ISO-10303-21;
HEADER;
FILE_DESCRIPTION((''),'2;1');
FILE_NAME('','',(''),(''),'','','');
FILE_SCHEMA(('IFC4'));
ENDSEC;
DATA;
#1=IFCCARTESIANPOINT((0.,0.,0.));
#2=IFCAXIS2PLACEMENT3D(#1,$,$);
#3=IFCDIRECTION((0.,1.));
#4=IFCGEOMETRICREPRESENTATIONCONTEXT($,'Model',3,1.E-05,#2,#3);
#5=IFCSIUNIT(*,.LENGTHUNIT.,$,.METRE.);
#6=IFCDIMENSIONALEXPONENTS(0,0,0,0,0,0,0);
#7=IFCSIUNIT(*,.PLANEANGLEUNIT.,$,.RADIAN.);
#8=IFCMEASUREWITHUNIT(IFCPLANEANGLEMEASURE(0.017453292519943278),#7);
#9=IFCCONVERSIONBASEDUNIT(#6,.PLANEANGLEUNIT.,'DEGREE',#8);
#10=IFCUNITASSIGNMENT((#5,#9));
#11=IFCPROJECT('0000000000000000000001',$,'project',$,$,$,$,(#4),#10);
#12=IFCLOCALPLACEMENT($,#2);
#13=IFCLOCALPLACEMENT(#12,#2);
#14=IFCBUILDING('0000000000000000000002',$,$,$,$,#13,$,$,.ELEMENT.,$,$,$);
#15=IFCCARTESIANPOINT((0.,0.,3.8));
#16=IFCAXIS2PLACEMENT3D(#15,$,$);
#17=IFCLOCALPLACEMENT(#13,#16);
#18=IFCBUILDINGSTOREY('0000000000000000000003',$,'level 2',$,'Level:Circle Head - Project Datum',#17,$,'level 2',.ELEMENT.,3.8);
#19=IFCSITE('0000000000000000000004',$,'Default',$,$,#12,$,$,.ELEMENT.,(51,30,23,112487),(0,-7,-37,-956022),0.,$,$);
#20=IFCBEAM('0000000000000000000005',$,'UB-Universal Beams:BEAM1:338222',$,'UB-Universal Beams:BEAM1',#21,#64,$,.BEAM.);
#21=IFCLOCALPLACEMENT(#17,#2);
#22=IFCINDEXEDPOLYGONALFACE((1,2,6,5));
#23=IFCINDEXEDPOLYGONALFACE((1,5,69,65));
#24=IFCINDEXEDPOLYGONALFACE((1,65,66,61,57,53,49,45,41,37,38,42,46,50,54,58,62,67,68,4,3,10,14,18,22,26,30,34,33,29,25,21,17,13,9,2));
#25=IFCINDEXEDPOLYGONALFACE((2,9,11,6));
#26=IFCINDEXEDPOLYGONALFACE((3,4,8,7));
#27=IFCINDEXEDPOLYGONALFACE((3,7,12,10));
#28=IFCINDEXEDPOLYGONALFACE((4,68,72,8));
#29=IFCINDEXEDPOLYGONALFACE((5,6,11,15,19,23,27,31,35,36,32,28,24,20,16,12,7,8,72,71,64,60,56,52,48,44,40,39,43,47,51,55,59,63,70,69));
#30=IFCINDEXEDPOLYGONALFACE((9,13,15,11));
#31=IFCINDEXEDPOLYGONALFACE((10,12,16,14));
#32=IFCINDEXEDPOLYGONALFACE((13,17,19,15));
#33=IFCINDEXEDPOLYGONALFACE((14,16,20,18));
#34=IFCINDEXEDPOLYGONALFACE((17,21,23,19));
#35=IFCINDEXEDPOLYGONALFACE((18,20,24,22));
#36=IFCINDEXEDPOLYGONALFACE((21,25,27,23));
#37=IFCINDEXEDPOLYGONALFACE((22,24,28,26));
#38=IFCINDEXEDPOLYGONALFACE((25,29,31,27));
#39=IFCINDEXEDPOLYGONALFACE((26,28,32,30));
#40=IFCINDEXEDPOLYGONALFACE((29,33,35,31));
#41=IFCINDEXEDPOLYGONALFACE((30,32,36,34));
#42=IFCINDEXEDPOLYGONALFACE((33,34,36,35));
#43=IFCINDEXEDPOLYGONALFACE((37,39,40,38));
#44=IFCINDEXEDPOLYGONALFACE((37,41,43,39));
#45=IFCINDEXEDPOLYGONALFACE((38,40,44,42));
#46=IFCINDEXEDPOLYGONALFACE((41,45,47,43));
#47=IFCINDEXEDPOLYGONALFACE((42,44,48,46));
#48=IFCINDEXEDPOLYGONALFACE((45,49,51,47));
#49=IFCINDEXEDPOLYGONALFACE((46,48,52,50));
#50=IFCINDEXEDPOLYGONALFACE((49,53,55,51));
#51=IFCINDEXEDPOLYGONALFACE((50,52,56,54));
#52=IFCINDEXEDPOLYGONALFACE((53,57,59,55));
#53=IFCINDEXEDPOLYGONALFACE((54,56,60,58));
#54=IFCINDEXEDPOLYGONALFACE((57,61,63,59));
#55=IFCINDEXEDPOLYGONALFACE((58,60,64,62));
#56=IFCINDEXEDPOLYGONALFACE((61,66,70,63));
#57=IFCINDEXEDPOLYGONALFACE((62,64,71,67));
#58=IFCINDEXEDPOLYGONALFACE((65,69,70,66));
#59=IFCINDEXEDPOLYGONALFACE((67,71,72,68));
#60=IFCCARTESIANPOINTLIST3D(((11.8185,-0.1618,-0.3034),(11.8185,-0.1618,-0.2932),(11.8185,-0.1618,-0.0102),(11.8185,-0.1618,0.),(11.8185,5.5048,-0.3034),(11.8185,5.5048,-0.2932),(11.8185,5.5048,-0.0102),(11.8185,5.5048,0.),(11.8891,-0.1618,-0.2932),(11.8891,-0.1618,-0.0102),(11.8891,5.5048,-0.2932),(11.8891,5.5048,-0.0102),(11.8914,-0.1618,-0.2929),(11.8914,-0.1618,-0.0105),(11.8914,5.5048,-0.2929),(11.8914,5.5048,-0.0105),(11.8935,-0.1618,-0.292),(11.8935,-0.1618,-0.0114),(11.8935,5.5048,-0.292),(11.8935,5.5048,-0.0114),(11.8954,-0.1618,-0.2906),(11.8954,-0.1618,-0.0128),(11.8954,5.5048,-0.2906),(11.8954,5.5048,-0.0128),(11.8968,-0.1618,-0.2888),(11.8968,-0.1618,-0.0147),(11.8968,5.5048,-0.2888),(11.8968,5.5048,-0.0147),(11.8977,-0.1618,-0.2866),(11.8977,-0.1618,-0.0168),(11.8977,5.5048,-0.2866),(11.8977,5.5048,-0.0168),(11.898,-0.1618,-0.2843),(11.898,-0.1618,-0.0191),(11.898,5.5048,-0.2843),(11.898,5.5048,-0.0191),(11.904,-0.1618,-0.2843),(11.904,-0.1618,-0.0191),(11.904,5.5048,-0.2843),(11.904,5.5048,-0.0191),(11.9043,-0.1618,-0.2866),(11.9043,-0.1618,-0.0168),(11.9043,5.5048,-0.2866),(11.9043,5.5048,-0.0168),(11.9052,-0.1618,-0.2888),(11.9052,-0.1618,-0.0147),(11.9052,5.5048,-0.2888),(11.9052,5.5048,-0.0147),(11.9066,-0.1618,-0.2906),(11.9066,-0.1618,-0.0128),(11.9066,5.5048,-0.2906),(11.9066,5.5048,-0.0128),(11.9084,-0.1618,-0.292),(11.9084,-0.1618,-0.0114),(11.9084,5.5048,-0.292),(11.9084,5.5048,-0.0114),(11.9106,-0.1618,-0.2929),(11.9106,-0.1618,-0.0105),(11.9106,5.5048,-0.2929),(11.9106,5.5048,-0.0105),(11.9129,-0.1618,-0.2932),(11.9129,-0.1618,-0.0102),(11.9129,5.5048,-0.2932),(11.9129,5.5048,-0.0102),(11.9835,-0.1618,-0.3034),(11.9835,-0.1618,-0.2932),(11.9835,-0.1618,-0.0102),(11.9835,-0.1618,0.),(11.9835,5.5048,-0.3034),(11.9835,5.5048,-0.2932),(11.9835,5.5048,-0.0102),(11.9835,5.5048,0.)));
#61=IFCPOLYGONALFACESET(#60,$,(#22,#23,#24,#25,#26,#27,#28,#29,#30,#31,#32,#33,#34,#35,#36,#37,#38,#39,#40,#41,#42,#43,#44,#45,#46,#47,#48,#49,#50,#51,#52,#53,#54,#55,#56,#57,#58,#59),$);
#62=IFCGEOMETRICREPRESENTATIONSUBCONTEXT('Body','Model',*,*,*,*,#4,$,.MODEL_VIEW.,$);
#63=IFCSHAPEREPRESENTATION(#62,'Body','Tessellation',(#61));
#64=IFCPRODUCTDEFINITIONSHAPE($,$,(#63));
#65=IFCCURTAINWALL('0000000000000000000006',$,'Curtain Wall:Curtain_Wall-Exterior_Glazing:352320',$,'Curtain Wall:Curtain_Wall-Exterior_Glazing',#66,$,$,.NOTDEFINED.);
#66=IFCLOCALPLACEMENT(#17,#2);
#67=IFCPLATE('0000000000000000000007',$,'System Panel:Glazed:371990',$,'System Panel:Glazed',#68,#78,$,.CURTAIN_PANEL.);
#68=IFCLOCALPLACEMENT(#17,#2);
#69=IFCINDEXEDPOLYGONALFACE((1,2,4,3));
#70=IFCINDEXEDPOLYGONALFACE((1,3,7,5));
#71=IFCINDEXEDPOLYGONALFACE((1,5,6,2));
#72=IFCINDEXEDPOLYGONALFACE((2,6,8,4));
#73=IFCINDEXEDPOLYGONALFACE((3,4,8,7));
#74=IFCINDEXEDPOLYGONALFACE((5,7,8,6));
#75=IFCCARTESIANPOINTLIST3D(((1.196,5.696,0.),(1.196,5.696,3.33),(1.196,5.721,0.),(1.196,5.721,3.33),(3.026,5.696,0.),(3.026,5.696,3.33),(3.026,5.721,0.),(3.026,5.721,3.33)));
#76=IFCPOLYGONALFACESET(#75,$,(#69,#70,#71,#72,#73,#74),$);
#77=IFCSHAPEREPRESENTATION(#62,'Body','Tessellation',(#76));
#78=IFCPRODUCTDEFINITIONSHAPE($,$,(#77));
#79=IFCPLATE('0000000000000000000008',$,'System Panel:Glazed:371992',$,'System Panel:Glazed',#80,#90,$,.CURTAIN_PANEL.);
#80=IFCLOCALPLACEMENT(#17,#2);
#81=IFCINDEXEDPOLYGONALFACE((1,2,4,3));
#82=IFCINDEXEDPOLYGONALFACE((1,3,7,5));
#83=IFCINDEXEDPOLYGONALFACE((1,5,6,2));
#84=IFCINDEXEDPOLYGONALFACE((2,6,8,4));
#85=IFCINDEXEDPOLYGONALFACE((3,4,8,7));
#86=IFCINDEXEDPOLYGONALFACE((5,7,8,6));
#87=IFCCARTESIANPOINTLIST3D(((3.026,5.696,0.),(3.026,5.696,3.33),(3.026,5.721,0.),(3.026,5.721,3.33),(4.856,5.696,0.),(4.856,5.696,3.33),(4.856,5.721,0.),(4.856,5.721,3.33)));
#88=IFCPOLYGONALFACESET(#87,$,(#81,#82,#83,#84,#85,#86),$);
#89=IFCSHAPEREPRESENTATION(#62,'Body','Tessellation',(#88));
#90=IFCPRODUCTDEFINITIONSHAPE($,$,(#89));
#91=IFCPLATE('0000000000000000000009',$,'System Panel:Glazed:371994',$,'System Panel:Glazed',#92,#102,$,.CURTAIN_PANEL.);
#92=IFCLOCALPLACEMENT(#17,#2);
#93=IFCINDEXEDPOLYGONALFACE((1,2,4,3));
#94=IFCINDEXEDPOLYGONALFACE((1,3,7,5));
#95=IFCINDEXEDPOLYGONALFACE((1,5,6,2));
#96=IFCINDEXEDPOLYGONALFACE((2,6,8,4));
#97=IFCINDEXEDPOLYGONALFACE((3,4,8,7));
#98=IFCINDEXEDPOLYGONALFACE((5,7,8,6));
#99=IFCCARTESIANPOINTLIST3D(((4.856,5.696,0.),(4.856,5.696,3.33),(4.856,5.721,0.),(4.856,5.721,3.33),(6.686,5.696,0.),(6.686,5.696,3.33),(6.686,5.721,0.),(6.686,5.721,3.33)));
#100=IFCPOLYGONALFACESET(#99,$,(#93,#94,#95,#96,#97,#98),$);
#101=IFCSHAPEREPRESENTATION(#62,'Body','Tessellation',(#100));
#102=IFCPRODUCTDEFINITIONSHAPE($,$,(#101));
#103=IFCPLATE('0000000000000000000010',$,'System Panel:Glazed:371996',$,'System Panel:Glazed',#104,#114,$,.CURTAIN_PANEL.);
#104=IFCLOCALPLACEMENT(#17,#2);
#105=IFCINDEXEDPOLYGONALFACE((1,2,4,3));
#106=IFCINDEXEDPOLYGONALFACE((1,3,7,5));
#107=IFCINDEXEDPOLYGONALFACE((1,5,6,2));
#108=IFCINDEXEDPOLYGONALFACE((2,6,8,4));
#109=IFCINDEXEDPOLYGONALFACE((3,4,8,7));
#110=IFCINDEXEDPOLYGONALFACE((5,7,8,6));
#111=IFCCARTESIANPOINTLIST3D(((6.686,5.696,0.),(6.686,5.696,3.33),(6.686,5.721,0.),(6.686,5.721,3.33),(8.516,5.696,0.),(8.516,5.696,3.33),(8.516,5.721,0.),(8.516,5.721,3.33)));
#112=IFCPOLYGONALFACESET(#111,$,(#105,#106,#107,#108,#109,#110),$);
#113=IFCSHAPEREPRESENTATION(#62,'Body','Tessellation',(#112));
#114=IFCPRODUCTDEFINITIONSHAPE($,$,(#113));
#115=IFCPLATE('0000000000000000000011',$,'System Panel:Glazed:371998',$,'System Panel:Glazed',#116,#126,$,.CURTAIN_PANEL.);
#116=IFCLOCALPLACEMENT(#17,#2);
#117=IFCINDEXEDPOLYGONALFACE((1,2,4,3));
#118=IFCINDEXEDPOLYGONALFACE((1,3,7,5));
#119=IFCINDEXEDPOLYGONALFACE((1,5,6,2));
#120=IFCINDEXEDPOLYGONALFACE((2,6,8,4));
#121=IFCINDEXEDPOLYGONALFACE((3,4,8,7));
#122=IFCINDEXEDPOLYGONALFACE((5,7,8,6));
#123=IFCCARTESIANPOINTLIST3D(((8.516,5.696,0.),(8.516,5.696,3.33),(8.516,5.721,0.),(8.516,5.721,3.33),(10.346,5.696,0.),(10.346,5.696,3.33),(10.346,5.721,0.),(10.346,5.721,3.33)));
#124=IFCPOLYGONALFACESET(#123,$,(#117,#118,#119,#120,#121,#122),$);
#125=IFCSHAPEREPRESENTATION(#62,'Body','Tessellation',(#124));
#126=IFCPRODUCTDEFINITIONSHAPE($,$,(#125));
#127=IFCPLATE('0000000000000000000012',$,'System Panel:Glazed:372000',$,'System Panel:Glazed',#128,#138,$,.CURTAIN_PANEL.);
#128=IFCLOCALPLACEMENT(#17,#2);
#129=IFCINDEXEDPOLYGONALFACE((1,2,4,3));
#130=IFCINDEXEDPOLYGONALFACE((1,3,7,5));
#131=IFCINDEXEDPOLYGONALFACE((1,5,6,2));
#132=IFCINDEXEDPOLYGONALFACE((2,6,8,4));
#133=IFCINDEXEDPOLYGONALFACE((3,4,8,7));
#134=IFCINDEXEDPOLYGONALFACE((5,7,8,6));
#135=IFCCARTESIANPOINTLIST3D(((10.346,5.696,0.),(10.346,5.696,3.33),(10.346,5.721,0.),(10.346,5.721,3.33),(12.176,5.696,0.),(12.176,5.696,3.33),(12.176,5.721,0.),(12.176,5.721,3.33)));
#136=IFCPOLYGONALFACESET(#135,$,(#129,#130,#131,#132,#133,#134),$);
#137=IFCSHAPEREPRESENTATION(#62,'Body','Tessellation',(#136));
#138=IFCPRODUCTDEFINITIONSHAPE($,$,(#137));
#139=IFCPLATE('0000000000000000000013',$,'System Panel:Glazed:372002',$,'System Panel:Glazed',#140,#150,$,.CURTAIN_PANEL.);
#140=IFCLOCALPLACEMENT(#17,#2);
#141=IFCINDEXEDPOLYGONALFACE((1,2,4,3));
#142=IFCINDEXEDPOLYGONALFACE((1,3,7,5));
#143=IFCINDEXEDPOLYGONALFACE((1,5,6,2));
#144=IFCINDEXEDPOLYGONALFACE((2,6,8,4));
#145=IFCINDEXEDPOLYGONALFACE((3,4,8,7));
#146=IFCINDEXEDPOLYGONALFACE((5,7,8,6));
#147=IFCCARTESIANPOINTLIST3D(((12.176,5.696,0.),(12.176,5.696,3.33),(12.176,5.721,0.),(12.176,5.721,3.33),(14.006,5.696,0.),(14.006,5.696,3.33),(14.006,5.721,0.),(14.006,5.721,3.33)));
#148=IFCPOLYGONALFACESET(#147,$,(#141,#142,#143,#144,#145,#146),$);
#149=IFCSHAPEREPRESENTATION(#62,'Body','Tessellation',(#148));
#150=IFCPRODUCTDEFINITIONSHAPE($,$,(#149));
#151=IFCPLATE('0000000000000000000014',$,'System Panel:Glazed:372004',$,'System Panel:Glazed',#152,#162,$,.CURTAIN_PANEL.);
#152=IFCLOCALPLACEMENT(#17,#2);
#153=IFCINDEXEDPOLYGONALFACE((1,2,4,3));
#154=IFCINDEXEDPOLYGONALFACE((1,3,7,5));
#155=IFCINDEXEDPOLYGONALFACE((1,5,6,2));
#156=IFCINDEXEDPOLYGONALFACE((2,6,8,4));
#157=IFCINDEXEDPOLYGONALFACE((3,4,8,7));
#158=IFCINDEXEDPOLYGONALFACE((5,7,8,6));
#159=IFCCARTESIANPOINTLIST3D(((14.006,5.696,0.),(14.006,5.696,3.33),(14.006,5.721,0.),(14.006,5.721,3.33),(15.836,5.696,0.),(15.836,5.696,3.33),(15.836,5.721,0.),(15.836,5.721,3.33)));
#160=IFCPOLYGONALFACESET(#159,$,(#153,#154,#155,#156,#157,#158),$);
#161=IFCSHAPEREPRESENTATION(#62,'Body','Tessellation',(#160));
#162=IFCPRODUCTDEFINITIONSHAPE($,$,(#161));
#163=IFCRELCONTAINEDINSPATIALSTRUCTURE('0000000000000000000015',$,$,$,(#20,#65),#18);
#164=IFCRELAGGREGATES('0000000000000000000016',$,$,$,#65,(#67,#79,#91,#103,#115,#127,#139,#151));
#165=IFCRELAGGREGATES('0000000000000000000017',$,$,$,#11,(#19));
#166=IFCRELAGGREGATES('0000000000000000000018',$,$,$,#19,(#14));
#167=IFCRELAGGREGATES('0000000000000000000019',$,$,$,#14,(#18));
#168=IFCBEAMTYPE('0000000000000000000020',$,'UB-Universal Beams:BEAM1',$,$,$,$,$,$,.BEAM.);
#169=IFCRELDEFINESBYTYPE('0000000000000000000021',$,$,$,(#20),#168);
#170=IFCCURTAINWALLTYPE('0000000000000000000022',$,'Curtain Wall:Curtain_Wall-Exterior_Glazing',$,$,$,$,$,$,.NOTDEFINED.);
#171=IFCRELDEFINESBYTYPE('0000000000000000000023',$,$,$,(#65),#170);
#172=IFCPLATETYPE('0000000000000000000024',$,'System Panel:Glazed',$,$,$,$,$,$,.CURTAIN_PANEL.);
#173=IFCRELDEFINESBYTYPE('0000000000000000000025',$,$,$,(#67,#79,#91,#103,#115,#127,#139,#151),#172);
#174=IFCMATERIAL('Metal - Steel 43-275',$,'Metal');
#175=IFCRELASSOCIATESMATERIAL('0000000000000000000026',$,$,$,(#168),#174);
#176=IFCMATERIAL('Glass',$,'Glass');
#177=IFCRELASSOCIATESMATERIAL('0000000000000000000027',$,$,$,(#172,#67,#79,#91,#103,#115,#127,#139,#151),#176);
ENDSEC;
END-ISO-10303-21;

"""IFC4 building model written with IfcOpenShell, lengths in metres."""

from ifc_helpers import new_model, entity, si_unit, converted_unit, direction, frame, frame_2d, origin, origin_2d_with_axis, place, context, subcontext, project, spatial, polyline, circle_curve, parameter, trimmed, segment, composite_curve, rectangle, outline, extrude, source, transform, mapped, material, material_profile, profile_set, type_object, type_shapes, element, aggregate, save


model = new_model("IFC4")

# Units and contexts
model_context = context("Model", 3, precision=1e-05, world=origin(), true_north=direction((0.0, 1.0)))
body_context = subcontext(model_context, "Body", "Model", "MODEL_VIEW")
ifc_project = project(units=[si_unit("LENGTHUNIT", "METRE"), converted_unit("PLANEANGLEUNIT", "DEGREE", entity("IfcPlaneAngleMeasure", 0.017453292519943278), si_unit("PLANEANGLEUNIT", "RADIAN"), dimensions=[0, 0, 0, 0, 0, 0, 0])], contexts=[model_context])

# Site, building, storey
site_placement = place(None, origin())
site = spatial("IfcSite", under=ifc_project, at=site_placement, Name="Default", CompositionType="ELEMENT", RefLatitude=(51, 30, 23, 112487), RefLongitude=(0, -7, -37, -956022), RefElevation=0.0)
building_placement = place(site_placement, origin())
building = spatial("IfcBuilding", under=site, at=building_placement, CompositionType="ELEMENT")
storey_placement = place(building_placement, frame((0.0, 0.0, 3.8)))
storey = spatial("IfcBuildingStorey", under=building, at=storey_placement, Name="level 2", ObjectType="Level:Circle Head - Project Datum", LongName="level 2", CompositionType="ELEMENT", Elevation=3.8)

# Shared definitions
ifc_material_1 = material(Name="Metal - Steel 43-275", Category="Metal")

# Beam
ifc_material_profile_1 = material_profile(ifc_material_1, outline(composite_curve([segment(polyline([(-0.0825, -0.1415), (-0.0825, -0.1517)]), True, "CONTINUOUS"), segment(polyline([(-0.0825, -0.1517), (0.0825, -0.1517)]), True, "CONTINUOUS"), segment(polyline([(0.0825, -0.1517), (0.0825, -0.1415)]), True, "CONTINUOUS"), segment(polyline([(0.0825, -0.1415), (0.0119, -0.1415)]), True, "CONTINUOUS"), segment(trimmed(circle_curve(frame_2d((0.0119, -0.1326), x_axis=(1.0, 0.0)), 0.0089), [parameter(180.0)], [parameter(270.0)], True, "PARAMETER"), False, "CONTINUOUS"), segment(polyline([(0.003, -0.1326), (0.003, 0.1326)]), True, "CONTINUOUS"), segment(trimmed(circle_curve(frame_2d((0.0119, 0.1326), x_axis=(1.0, 0.0)), 0.0089), [parameter(90.0)], [parameter(180.0)], True, "PARAMETER"), False, "CONTINUOUS"), segment(polyline([(0.0119, 0.1415), (0.0825, 0.1415)]), True, "CONTINUOUS"), segment(polyline([(0.0825, 0.1415), (0.0825, 0.1517)]), True, "CONTINUOUS"), segment(polyline([(0.0825, 0.1517), (-0.0825, 0.1517)]), True, "CONTINUOUS"), segment(polyline([(-0.0825, 0.1517), (-0.0825, 0.1415)]), True, "CONTINUOUS"), segment(polyline([(-0.0825, 0.1415), (-0.0119, 0.1415)]), True, "CONTINUOUS"), segment(trimmed(circle_curve(frame_2d((-0.0119, 0.1326), x_axis=(1.0, 0.0)), 0.0089), [parameter(360.0)], [parameter(90.0)], True, "PARAMETER"), False, "CONTINUOUS"), segment(polyline([(-0.003, 0.1326), (-0.003, -0.1326)]), True, "CONTINUOUS"), segment(trimmed(circle_curve(frame_2d((-0.0119, -0.1326), x_axis=(1.0, 0.0)), 0.0089), [parameter(270.0)], [parameter(360.0)], True, "PARAMETER"), False, "CONTINUOUS"), segment(polyline([(-0.0119, -0.1415), (-0.0825, -0.1415)]), True, "CONTINUOUS")], self_intersect=False)), Name="BEAM1")
ifc_profile_set_1 = profile_set([ifc_material_profile_1], Name="BEAM1")
beam_type_1 = type_object("IfcBeamType", Name="UB-Universal Beams:BEAM1", PredefinedType="BEAM", material=ifc_profile_set_1)
shared_shape_1 = source(origin(), body_context, "Body", "SweptSolid", [
    extrude(outline(composite_curve([segment(polyline([(-0.0825, -0.1415), (-0.0825, -0.1517)]), True, "CONTINUOUS"), segment(polyline([(-0.0825, -0.1517), (0.0825, -0.1517)]), True, "CONTINUOUS"), segment(polyline([(0.0825, -0.1517), (0.0825, -0.1415)]), True, "CONTINUOUS"), segment(polyline([(0.0825, -0.1415), (0.0119, -0.1415)]), True, "CONTINUOUS"), segment(trimmed(circle_curve(frame_2d((0.0119, -0.1326), x_axis=(1.0, 0.0)), 0.0089), [parameter(180.0)], [parameter(270.0)], True, "PARAMETER"), False, "CONTINUOUS"), segment(polyline([(0.003, -0.1326), (0.003, 0.1326)]), True, "CONTINUOUS"), segment(trimmed(circle_curve(frame_2d((0.0119, 0.1326), x_axis=(1.0, 0.0)), 0.0089), [parameter(90.0)], [parameter(180.0)], True, "PARAMETER"), False, "CONTINUOUS"), segment(polyline([(0.0119, 0.1415), (0.0825, 0.1415)]), True, "CONTINUOUS"), segment(polyline([(0.0825, 0.1415), (0.0825, 0.1517)]), True, "CONTINUOUS"), segment(polyline([(0.0825, 0.1517), (-0.0825, 0.1517)]), True, "CONTINUOUS"), segment(polyline([(-0.0825, 0.1517), (-0.0825, 0.1415)]), True, "CONTINUOUS"), segment(polyline([(-0.0825, 0.1415), (-0.0119, 0.1415)]), True, "CONTINUOUS"), segment(trimmed(circle_curve(frame_2d((-0.0119, 0.1326), x_axis=(1.0, 0.0)), 0.0089), [parameter(360.0)], [parameter(90.0)], True, "PARAMETER"), False, "CONTINUOUS"), segment(polyline([(-0.003, 0.1326), (-0.003, -0.1326)]), True, "CONTINUOUS"), segment(trimmed(circle_curve(frame_2d((-0.0119, -0.1326), x_axis=(1.0, 0.0)), 0.0089), [parameter(270.0)], [parameter(360.0)], True, "PARAMETER"), False, "CONTINUOUS"), segment(polyline([(-0.0119, -0.1415), (-0.0825, -0.1415)]), True, "CONTINUOUS")], self_intersect=False)), frame((-2.8333, 0.0, 0.0), z_axis=(-1.0, 0.0, 0.0), x_axis=(0.0, -1.0, 0.0)), (0.0, 0.0, -1.0), 5.6666),
])
type_shapes(beam_type_1, [shared_shape_1])
for number, where, z_axis, x_axis, name in (
    (1, (11.901, 2.6715, -0.1517), (0.0, 0.0, 1.0), (0.0, -1.0, 0.0), "UB-Universal Beams:BEAM1:338222"),
):
    element("IfcBeam", number, at=place(storey_placement, frame(where, z_axis=z_axis, x_axis=x_axis)), inside=storey, type_object=beam_type_1, Name=name, ObjectType="UB-Universal Beams:BEAM1", PredefinedType="BEAM", context=body_context, shape_type="MappedRepresentation", body=[
        mapped(shared_shape_1, transform((0.0, 0.0, 0.0), scale=1.0)),
    ])

# Curtain wall, plates
curtain_wall_type = type_object("IfcCurtainWallType", Name="Curtain Wall:Curtain_Wall-Exterior_Glazing", PredefinedType="NOTDEFINED")
curtain_wall_1_placement = place(storey_placement, frame((0.0, 0.0, -3.8)))
curtain_wall_1 = element("IfcCurtainWall", 2, at=curtain_wall_1_placement, inside=storey, type_object=curtain_wall_type, Name="Curtain Wall:Curtain_Wall-Exterior_Glazing:352320", ObjectType="Curtain Wall:Curtain_Wall-Exterior_Glazing", PredefinedType="NOTDEFINED")
ifc_material_2 = material(Name="Glass", Category="Glass")
plate_type = type_object("IfcPlateType", Name="System Panel:Glazed", PredefinedType="CURTAIN_PANEL", material=ifc_material_2)
shared_shape_2 = source(origin(), body_context, "Body", "SweptSolid", [
    extrude(rectangle(XDim=0.025, YDim=1.83, at=origin_2d_with_axis()), frame((0.915, 0.0125, 0.0), z_axis=(0.0, 0.0, 1.0), x_axis=(0.0, 1.0, 0.0)), (0.0, 0.0, 1.0), 3.33),
])
type_shapes(plate_type, [shared_shape_2])
plate_1_placement = place(curtain_wall_1_placement, frame((1.196, 5.696, 3.8)))
plate_1 = element("IfcPlate", 3, at=plate_1_placement, type_object=plate_type, material=ifc_material_2, Name="System Panel:Glazed:371990", ObjectType="System Panel:Glazed", PredefinedType="CURTAIN_PANEL", context=body_context, shape_type="MappedRepresentation", body=[
    mapped(shared_shape_2, transform((0.0, 0.0, 0.0), scale=1.0)),
])
plate_2_placement = place(curtain_wall_1_placement, frame((3.026, 5.696, 3.8)))
plate_2 = element("IfcPlate", 4, at=plate_2_placement, type_object=plate_type, material=ifc_material_2, Name="System Panel:Glazed:371992", ObjectType="System Panel:Glazed", PredefinedType="CURTAIN_PANEL", context=body_context, shape_type="MappedRepresentation", body=[
    mapped(shared_shape_2, transform((0.0, 0.0, 0.0), scale=1.0)),
])
plate_3_placement = place(curtain_wall_1_placement, frame((4.856, 5.696, 3.8)))
plate_3 = element("IfcPlate", 5, at=plate_3_placement, type_object=plate_type, material=ifc_material_2, Name="System Panel:Glazed:371994", ObjectType="System Panel:Glazed", PredefinedType="CURTAIN_PANEL", context=body_context, shape_type="MappedRepresentation", body=[
    mapped(shared_shape_2, transform((0.0, 0.0, 0.0), scale=1.0)),
])
plate_4_placement = place(curtain_wall_1_placement, frame((6.686, 5.696, 3.8)))
plate_4 = element("IfcPlate", 6, at=plate_4_placement, type_object=plate_type, material=ifc_material_2, Name="System Panel:Glazed:371996", ObjectType="System Panel:Glazed", PredefinedType="CURTAIN_PANEL", context=body_context, shape_type="MappedRepresentation", body=[
    mapped(shared_shape_2, transform((0.0, 0.0, 0.0), scale=1.0)),
])
plate_5_placement = place(curtain_wall_1_placement, frame((8.516, 5.696, 3.8)))
plate_5 = element("IfcPlate", 7, at=plate_5_placement, type_object=plate_type, material=ifc_material_2, Name="System Panel:Glazed:371998", ObjectType="System Panel:Glazed", PredefinedType="CURTAIN_PANEL", context=body_context, shape_type="MappedRepresentation", body=[
    mapped(shared_shape_2, transform((0.0, 0.0, 0.0), scale=1.0)),
])
plate_6_placement = place(curtain_wall_1_placement, frame((10.346, 5.696, 3.8)))
plate_6 = element("IfcPlate", 8, at=plate_6_placement, type_object=plate_type, material=ifc_material_2, Name="System Panel:Glazed:372000", ObjectType="System Panel:Glazed", PredefinedType="CURTAIN_PANEL", context=body_context, shape_type="MappedRepresentation", body=[
    mapped(shared_shape_2, transform((0.0, 0.0, 0.0), scale=1.0)),
])
plate_7_placement = place(curtain_wall_1_placement, frame((12.176, 5.696, 3.8)))
plate_7 = element("IfcPlate", 9, at=plate_7_placement, type_object=plate_type, material=ifc_material_2, Name="System Panel:Glazed:372002", ObjectType="System Panel:Glazed", PredefinedType="CURTAIN_PANEL", context=body_context, shape_type="MappedRepresentation", body=[
    mapped(shared_shape_2, transform((0.0, 0.0, 0.0), scale=1.0)),
])
plate_8_placement = place(curtain_wall_1_placement, frame((14.006, 5.696, 3.8)))
plate_8 = element("IfcPlate", 10, at=plate_8_placement, type_object=plate_type, material=ifc_material_2, Name="System Panel:Glazed:372004", ObjectType="System Panel:Glazed", PredefinedType="CURTAIN_PANEL", context=body_context, shape_type="MappedRepresentation", body=[
    mapped(shared_shape_2, transform((0.0, 0.0, 0.0), scale=1.0)),
])
aggregate(curtain_wall_1, [plate_1, plate_2, plate_3, plate_4, plate_5, plate_6, plate_7, plate_8])

save(model, "model.ifc")
